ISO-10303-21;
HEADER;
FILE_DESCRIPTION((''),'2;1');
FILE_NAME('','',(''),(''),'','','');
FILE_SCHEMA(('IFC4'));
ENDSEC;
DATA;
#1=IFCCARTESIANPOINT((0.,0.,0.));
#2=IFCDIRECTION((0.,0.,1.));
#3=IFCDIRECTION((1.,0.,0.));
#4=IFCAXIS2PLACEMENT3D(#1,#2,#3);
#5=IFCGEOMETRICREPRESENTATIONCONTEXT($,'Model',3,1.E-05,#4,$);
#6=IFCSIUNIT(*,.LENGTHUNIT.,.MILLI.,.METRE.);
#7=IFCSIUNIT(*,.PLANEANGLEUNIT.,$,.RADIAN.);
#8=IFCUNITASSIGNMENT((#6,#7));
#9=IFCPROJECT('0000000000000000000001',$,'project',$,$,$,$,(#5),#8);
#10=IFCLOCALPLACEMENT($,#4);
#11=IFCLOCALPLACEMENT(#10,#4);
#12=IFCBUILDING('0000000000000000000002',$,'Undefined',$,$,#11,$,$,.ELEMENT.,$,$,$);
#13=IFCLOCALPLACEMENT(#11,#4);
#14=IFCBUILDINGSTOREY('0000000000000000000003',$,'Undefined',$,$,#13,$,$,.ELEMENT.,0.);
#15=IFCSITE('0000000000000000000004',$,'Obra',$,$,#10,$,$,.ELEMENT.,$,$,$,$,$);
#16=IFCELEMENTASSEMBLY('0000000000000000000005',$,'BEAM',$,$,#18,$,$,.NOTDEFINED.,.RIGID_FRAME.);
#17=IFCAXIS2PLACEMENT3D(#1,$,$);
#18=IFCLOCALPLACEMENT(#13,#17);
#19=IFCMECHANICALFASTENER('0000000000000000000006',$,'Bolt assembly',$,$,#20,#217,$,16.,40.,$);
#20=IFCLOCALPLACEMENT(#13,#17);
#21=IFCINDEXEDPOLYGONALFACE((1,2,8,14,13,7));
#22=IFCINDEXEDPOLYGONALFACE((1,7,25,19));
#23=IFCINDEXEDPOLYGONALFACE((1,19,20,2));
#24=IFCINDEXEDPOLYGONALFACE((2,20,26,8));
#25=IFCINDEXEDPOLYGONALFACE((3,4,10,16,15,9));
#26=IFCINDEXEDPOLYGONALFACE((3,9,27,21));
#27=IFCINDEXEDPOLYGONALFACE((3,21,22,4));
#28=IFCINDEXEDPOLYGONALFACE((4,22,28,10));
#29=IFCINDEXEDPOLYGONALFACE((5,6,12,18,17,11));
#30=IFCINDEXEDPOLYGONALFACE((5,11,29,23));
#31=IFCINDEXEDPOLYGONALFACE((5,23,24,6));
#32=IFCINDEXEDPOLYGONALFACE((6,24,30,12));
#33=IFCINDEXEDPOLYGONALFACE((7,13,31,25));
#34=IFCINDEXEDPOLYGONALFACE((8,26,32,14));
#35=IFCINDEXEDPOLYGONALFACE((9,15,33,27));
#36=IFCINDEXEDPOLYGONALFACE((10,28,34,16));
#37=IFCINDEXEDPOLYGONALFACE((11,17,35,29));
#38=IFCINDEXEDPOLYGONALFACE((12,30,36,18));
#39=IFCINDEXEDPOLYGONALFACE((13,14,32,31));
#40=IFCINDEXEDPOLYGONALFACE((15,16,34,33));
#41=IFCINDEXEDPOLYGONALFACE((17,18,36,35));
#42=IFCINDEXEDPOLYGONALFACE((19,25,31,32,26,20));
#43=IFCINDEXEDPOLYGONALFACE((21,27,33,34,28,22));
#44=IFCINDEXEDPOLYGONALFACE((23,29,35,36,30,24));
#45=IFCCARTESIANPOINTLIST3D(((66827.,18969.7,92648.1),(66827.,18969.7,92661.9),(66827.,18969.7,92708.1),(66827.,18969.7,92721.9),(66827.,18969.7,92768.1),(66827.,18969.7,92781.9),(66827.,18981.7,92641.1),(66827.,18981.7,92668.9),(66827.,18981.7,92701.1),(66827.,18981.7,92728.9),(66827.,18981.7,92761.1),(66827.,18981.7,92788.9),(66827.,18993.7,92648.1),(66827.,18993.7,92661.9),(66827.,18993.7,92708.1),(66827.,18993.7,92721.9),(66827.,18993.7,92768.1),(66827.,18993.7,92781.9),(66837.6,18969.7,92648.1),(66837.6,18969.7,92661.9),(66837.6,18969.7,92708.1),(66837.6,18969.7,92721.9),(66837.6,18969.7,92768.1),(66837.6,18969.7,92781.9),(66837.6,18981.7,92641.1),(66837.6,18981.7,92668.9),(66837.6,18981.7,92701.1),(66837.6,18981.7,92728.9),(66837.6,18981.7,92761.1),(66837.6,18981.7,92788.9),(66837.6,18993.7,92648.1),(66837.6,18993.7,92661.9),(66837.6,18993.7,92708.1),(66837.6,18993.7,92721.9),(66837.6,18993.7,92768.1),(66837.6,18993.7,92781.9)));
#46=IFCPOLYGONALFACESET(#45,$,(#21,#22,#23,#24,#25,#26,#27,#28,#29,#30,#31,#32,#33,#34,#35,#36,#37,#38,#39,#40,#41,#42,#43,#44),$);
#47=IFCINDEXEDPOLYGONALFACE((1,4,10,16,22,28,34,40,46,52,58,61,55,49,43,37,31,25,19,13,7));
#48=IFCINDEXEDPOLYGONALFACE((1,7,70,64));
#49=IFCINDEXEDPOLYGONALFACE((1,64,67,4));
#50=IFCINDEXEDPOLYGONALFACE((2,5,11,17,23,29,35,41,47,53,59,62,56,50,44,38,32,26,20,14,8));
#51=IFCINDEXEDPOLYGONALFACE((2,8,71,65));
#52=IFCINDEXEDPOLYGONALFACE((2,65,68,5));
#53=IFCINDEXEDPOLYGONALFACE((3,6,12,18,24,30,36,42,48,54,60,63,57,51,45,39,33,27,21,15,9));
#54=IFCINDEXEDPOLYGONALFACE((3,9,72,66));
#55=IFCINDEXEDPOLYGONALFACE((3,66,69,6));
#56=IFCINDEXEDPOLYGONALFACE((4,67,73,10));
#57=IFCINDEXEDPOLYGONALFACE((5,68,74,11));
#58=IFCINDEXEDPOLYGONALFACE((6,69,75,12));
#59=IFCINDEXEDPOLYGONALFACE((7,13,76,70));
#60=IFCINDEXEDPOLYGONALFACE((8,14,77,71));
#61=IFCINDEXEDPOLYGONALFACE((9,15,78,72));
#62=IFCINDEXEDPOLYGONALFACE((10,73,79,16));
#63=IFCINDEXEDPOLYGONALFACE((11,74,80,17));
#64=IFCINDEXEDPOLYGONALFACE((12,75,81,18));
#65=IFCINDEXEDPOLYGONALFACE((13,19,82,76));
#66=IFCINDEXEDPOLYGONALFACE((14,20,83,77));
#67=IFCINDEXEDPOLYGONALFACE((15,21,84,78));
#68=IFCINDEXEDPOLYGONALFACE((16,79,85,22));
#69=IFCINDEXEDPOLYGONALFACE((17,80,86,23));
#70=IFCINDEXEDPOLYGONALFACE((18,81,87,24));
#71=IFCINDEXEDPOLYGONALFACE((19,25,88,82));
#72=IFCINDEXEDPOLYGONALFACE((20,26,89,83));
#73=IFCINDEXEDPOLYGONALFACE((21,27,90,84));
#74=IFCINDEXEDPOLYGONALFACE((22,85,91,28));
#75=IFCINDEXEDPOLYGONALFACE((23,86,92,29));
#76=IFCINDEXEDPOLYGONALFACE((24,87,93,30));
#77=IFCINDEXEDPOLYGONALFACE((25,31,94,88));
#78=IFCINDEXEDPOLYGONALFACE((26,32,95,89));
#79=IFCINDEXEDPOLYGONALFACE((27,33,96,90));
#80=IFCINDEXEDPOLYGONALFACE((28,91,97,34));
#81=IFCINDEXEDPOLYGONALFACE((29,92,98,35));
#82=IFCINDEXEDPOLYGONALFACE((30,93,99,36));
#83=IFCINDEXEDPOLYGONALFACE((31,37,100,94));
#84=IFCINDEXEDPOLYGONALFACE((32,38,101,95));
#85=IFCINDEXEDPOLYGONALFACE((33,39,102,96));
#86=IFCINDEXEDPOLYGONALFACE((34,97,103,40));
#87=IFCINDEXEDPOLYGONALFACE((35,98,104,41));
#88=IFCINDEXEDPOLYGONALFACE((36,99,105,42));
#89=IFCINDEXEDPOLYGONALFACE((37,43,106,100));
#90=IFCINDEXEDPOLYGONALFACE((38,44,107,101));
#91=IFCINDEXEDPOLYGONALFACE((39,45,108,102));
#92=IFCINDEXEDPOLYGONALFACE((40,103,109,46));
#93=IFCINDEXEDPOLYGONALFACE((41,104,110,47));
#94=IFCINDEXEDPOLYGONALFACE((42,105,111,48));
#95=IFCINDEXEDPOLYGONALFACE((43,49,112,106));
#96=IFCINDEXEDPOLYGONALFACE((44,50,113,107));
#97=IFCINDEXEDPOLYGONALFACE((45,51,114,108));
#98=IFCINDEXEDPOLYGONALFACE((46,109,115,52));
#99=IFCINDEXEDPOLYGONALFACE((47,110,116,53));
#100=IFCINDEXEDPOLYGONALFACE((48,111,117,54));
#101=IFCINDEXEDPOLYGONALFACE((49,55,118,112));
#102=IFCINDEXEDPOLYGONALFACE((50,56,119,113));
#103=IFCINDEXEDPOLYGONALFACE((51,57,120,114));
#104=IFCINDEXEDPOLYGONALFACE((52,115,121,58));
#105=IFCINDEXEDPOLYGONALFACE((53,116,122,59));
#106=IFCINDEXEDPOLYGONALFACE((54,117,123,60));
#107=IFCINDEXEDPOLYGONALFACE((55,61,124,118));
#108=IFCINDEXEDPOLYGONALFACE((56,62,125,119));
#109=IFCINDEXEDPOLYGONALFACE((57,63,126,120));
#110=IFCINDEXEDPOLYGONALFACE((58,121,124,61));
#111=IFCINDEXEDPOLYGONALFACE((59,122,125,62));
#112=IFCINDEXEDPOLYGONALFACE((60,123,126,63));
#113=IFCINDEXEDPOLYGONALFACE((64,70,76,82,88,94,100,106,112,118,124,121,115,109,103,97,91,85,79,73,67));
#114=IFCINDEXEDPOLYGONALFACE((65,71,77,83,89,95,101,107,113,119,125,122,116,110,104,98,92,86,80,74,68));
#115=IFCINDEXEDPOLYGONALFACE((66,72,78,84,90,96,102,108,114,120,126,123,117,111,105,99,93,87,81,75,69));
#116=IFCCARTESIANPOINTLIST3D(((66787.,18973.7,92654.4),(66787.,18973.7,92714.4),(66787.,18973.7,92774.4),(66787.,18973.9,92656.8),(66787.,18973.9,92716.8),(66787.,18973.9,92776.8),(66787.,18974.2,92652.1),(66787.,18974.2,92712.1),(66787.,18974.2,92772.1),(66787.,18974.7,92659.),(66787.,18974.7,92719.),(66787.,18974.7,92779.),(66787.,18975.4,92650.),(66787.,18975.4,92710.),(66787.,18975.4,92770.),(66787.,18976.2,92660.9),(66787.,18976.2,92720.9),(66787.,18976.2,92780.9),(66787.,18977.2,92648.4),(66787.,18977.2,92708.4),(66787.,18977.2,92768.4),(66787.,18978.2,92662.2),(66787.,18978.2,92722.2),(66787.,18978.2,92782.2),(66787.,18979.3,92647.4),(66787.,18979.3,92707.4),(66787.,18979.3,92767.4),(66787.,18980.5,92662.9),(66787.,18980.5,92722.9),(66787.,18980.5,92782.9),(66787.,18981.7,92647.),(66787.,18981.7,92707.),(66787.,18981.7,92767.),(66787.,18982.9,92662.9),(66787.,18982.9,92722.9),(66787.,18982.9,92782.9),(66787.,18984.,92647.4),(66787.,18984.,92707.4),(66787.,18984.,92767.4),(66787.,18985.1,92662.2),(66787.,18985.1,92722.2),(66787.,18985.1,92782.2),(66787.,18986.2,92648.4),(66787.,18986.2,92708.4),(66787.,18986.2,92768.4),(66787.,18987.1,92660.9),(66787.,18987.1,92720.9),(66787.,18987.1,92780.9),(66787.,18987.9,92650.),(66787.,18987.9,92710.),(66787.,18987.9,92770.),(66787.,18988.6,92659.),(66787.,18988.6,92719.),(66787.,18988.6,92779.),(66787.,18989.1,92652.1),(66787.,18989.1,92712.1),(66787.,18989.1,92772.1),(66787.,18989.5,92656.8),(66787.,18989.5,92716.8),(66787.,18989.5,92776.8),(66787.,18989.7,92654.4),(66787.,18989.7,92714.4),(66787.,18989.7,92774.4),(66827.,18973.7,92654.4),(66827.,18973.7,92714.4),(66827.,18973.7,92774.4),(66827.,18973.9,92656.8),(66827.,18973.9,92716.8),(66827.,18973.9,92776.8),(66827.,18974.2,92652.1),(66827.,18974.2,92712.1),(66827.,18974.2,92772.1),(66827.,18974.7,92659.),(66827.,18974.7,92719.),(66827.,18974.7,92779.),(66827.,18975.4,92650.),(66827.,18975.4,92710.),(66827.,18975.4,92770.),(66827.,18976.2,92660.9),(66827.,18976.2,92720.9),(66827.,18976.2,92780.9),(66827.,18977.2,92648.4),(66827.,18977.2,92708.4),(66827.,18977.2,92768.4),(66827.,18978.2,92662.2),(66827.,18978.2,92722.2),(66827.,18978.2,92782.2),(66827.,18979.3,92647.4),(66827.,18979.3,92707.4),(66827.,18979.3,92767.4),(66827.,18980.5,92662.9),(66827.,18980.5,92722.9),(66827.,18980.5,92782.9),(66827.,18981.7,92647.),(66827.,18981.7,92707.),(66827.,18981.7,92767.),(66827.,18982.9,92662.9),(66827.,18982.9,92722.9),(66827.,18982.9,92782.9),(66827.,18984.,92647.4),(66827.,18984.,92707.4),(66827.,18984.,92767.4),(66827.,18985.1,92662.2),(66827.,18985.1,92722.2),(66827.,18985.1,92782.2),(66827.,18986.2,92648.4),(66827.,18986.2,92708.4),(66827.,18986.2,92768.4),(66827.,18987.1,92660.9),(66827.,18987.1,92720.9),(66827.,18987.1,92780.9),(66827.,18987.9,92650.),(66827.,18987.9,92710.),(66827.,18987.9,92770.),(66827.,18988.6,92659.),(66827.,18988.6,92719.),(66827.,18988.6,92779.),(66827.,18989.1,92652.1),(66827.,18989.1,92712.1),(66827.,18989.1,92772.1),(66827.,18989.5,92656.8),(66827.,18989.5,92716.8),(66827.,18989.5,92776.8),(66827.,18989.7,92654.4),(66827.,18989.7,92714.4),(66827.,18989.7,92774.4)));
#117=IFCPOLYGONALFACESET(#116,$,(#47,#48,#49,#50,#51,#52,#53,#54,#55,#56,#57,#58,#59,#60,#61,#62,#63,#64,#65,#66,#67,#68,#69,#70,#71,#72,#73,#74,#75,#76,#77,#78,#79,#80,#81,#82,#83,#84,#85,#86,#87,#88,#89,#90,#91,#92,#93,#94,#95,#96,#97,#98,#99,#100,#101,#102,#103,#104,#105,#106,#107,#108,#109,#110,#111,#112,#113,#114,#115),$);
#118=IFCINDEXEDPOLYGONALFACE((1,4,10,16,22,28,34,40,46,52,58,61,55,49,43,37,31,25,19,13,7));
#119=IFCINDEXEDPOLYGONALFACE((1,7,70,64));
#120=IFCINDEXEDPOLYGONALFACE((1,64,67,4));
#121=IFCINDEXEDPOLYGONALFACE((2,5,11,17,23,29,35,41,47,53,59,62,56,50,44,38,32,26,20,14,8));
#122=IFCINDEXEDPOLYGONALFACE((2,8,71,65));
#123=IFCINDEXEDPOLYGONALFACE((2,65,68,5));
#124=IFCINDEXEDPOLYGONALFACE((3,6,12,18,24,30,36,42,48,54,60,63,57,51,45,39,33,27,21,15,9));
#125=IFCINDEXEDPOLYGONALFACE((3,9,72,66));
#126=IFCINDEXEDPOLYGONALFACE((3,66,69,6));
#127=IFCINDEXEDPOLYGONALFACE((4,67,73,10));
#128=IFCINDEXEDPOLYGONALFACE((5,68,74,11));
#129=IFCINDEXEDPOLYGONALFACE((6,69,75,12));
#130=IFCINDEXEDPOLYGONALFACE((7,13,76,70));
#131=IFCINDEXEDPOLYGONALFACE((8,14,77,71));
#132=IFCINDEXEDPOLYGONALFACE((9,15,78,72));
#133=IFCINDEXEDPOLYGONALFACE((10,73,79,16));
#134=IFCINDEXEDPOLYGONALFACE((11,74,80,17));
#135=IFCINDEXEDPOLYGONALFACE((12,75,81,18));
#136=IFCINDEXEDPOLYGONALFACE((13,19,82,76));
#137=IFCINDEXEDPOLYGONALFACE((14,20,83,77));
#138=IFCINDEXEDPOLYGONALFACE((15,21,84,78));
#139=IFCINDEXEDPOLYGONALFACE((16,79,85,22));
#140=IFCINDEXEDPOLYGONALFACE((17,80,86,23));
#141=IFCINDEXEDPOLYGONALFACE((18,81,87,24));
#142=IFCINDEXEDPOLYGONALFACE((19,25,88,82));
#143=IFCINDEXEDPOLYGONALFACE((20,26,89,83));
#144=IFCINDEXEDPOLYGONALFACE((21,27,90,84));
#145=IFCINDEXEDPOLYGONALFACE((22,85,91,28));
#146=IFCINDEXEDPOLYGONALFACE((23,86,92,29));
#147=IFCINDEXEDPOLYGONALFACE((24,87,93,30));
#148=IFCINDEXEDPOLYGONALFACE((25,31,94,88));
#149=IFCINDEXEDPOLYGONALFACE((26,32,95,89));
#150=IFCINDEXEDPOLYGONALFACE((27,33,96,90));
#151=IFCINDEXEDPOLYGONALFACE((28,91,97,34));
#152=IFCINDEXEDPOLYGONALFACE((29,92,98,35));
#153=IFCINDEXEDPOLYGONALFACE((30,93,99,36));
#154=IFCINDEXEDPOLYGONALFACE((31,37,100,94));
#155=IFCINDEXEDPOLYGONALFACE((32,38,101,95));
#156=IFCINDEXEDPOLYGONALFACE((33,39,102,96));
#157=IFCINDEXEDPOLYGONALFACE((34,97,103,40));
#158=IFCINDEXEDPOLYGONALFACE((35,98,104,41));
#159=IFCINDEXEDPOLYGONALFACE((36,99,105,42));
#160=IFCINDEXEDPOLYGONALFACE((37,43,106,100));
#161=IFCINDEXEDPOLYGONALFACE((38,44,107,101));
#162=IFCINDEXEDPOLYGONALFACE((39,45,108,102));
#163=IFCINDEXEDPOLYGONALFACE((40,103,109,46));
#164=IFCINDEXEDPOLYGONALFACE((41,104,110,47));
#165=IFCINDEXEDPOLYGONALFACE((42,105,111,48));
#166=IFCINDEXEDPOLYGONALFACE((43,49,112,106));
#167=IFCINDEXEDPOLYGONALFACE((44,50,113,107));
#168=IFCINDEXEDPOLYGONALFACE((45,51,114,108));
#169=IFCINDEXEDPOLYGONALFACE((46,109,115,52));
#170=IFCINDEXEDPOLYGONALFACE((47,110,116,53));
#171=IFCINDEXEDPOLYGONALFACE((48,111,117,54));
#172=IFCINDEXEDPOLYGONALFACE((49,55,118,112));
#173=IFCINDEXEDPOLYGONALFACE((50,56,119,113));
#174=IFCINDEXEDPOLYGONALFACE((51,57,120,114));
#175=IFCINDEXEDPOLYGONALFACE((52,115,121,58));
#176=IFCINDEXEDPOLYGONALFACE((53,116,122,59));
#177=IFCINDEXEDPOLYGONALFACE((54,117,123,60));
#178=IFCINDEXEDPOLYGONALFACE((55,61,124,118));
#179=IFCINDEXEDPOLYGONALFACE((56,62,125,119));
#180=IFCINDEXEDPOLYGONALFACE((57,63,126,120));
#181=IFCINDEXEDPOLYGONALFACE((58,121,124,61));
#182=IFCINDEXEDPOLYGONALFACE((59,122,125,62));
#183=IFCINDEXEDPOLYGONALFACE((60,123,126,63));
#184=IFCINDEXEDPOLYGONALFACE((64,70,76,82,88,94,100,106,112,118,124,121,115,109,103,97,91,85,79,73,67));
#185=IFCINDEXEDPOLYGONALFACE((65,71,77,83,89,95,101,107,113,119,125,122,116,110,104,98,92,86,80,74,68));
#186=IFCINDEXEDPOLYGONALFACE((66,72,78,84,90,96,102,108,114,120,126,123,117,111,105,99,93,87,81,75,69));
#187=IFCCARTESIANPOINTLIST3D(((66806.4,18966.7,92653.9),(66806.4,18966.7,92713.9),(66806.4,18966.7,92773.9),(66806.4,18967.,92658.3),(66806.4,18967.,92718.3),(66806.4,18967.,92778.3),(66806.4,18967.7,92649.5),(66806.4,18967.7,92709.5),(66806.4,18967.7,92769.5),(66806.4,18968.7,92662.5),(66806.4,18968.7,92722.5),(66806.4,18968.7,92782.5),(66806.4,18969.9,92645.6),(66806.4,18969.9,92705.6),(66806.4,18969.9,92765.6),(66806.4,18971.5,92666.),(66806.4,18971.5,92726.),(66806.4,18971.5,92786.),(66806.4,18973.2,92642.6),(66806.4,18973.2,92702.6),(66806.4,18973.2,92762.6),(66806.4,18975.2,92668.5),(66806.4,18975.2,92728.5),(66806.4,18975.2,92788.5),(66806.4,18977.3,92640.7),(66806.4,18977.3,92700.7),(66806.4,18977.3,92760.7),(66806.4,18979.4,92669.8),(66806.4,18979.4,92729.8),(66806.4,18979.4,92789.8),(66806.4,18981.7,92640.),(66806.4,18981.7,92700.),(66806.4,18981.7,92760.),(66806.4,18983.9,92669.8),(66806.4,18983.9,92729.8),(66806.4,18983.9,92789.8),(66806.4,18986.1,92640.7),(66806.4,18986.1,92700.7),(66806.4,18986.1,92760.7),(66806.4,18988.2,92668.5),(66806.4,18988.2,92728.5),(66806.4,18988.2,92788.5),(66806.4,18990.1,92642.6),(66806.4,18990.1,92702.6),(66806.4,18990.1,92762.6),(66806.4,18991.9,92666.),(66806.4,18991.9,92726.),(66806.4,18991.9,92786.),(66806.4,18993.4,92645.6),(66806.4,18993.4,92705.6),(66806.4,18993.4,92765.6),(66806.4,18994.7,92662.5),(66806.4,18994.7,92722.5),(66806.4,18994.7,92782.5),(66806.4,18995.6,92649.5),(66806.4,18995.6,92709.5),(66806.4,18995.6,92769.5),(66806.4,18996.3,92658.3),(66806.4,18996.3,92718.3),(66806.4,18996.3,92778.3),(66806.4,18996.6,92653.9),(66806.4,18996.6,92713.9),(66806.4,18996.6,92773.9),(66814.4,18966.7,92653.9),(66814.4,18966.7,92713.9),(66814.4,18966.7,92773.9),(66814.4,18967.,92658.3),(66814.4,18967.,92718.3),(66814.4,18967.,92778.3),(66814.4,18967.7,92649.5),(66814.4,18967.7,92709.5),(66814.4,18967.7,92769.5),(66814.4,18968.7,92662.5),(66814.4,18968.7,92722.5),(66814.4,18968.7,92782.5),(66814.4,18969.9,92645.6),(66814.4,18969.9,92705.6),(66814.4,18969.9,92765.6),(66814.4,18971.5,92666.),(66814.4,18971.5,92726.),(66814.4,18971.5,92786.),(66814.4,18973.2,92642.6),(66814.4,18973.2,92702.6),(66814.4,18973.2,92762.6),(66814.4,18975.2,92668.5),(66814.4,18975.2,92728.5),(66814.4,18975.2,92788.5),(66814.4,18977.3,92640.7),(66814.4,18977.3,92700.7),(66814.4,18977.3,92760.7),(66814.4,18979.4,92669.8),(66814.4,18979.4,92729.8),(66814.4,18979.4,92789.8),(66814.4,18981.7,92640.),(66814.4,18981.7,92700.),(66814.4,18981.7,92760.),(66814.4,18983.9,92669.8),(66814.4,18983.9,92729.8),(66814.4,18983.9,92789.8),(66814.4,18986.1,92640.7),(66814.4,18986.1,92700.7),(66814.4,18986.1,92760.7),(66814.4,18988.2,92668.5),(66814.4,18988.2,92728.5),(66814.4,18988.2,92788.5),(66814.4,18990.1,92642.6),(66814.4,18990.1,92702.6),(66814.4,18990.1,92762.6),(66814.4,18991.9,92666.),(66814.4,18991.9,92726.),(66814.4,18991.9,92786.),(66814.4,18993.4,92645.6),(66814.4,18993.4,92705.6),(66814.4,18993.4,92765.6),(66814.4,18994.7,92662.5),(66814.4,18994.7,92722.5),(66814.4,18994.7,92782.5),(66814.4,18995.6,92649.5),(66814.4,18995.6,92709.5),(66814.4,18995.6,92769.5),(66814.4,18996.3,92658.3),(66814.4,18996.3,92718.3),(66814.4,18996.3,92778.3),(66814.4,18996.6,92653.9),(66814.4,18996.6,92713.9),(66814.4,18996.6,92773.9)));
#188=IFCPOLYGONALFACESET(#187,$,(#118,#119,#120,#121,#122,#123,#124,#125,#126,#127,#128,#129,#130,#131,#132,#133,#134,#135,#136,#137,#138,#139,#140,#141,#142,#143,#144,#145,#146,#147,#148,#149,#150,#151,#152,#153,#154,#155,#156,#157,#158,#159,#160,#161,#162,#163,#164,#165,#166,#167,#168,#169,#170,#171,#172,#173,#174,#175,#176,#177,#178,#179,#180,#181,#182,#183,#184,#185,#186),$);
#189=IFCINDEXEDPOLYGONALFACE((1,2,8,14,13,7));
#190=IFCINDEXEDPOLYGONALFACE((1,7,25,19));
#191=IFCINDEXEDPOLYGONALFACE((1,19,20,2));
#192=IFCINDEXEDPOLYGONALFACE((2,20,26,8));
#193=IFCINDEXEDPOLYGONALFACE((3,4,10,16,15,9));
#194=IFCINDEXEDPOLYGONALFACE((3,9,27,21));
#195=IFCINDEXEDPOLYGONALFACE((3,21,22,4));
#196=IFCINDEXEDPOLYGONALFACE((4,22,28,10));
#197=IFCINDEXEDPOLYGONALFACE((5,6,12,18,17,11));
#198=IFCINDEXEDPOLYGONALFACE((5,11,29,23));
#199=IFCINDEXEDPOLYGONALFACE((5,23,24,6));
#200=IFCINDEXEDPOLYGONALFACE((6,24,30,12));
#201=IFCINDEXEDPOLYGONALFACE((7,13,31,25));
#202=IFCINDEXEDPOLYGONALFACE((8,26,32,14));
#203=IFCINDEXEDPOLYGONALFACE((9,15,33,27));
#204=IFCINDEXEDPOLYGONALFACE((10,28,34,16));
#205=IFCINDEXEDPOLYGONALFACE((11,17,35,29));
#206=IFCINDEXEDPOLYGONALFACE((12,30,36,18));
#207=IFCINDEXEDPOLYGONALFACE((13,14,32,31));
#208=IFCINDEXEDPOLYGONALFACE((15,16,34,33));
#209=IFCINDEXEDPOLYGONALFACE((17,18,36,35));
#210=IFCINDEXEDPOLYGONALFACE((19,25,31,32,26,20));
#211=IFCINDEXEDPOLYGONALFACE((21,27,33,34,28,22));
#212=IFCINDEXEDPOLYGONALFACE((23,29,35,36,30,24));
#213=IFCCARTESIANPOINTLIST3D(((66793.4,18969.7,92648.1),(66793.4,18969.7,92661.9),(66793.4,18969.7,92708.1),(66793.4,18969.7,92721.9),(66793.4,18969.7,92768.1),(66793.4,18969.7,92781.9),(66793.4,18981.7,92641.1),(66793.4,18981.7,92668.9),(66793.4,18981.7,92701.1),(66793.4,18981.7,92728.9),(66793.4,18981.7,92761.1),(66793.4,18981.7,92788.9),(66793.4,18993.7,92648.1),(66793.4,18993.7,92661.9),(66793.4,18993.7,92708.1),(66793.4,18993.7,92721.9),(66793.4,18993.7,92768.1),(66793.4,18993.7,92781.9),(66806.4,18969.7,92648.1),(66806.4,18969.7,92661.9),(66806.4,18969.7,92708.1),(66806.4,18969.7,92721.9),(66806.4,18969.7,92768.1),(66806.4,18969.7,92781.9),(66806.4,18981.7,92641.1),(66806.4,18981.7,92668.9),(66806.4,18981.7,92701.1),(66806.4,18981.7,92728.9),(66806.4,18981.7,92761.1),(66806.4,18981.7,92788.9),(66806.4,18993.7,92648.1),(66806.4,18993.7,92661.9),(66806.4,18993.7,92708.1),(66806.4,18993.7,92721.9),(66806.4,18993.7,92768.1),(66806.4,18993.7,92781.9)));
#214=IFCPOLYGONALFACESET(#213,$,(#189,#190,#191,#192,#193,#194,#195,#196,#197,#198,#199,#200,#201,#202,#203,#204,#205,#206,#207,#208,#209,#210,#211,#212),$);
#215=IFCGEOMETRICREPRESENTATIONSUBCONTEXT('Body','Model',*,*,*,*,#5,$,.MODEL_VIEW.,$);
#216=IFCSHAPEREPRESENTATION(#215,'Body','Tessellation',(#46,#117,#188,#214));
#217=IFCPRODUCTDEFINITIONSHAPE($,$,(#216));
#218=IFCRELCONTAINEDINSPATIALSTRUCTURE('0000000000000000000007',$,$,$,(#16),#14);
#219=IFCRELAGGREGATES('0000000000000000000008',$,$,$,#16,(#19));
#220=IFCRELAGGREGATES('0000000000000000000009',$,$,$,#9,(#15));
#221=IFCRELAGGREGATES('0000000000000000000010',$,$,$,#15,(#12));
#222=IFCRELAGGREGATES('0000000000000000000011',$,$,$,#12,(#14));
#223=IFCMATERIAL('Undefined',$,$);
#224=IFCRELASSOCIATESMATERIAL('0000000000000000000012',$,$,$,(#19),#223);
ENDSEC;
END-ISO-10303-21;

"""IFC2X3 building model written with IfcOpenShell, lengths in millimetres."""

from ifc_helpers import new_model, si_unit, frame, origin_with_axes, origin_2d_with_axis, place, context, subcontext, project, spatial, polyline, circle, outline, extrude, source, transform, mapped, material, element, aggregate, save


model = new_model("IFC2X3")

# Units and contexts
model_context = context("Model", 3, precision=1e-05, world=origin_with_axes())
body_context = subcontext(model_context, "Body", "Model", "MODEL_VIEW")
ifc_project = project(units=[si_unit("LENGTHUNIT", "METRE", prefix="MILLI"), si_unit("PLANEANGLEUNIT", "RADIAN")], contexts=[model_context])

# Site, building, storey
site_placement = place(None, origin_with_axes())
site = spatial("IfcSite", under=ifc_project, at=site_placement, Name="Obra", CompositionType="ELEMENT")
building_placement = place(site_placement, origin_with_axes())
building = spatial("IfcBuilding", under=site, at=building_placement, Name="Undefined", CompositionType="ELEMENT")
storey_placement = place(building_placement, origin_with_axes())
storey = spatial("IfcBuildingStorey", under=building, at=storey_placement, Name="Undefined", CompositionType="ELEMENT", Elevation=0.0)

# Element assembly, mechanical fastener
assembly_1_placement = place(storey_placement, origin_with_axes())
assembly_1 = element("IfcElementAssembly", 1, at=assembly_1_placement, inside=storey, Name="BEAM", AssemblyPlace="NOTDEFINED", PredefinedType="RIGID_FRAME")
ifc_material_1 = material(Name="Undefined")
shared_shape_1 = source(origin_with_axes(), body_context, "Body", "SweptSolid", [
    extrude(outline(polyline([(13.9, 0.0), (6.9, 12.0), (-6.9, 12.0), (-13.9, 0.0), (-6.9, -12.0), (6.9, -12.0), (13.9, 0.0)])), frame((0.0, -19.9, 0.0), z_axis=(0.0, 1.0, 0.0), x_axis=(1.0, 0.0, 0.0)), (0.0, 0.0, 1.0), 10.6),
    extrude(circle(Radius=8.0, at=origin_2d_with_axis()), frame((0.0, -9.3, 0.0), z_axis=(0.0, 1.0, 0.0), x_axis=(1.0, 0.0, 0.0)), (0.0, 0.0, 1.0), 40.0),
    extrude(circle(Radius=15.0, at=origin_2d_with_axis()), frame((0.0, 3.3, 0.0), z_axis=(0.0, 1.0, 0.0), x_axis=(1.0, 0.0, 0.0)), (0.0, 0.0, 1.0), 8.0),
    extrude(outline(polyline([(13.9, 0.0), (6.9, 12.0), (-6.9, 12.0), (-13.9, 0.0), (-6.9, -12.0), (6.9, -12.0), (13.9, 0.0)])), frame((0.0, 11.3, 0.0), z_axis=(0.0, 1.0, 0.0), x_axis=(1.0, 0.0, 0.0)), (0.0, 0.0, 1.0), 13.0),
])
mechanical_fastener_1_placement = place(assembly_1_placement, frame((66817.7, 18931.7, 92850.0), z_axis=(-0.000002, 1.0, 0.0), x_axis=(0.0, 0.0, -1.0)))
mechanical_fastener_1 = element("IfcMechanicalFastener", 2, at=mechanical_fastener_1_placement, material=ifc_material_1, Name="Bolt assembly", NominalDiameter=16.0, NominalLength=40.0, context=body_context, shape_type="MappedRepresentation", body=[
    mapped(shared_shape_1, transform((75.0, 0.0, 50.0))),
    mapped(shared_shape_1, transform((135.0, 0.0, 50.0))),
    mapped(shared_shape_1, transform((195.0, 0.0, 50.0))),
])
aggregate(assembly_1, [mechanical_fastener_1])

save(model, "model.ifc")
